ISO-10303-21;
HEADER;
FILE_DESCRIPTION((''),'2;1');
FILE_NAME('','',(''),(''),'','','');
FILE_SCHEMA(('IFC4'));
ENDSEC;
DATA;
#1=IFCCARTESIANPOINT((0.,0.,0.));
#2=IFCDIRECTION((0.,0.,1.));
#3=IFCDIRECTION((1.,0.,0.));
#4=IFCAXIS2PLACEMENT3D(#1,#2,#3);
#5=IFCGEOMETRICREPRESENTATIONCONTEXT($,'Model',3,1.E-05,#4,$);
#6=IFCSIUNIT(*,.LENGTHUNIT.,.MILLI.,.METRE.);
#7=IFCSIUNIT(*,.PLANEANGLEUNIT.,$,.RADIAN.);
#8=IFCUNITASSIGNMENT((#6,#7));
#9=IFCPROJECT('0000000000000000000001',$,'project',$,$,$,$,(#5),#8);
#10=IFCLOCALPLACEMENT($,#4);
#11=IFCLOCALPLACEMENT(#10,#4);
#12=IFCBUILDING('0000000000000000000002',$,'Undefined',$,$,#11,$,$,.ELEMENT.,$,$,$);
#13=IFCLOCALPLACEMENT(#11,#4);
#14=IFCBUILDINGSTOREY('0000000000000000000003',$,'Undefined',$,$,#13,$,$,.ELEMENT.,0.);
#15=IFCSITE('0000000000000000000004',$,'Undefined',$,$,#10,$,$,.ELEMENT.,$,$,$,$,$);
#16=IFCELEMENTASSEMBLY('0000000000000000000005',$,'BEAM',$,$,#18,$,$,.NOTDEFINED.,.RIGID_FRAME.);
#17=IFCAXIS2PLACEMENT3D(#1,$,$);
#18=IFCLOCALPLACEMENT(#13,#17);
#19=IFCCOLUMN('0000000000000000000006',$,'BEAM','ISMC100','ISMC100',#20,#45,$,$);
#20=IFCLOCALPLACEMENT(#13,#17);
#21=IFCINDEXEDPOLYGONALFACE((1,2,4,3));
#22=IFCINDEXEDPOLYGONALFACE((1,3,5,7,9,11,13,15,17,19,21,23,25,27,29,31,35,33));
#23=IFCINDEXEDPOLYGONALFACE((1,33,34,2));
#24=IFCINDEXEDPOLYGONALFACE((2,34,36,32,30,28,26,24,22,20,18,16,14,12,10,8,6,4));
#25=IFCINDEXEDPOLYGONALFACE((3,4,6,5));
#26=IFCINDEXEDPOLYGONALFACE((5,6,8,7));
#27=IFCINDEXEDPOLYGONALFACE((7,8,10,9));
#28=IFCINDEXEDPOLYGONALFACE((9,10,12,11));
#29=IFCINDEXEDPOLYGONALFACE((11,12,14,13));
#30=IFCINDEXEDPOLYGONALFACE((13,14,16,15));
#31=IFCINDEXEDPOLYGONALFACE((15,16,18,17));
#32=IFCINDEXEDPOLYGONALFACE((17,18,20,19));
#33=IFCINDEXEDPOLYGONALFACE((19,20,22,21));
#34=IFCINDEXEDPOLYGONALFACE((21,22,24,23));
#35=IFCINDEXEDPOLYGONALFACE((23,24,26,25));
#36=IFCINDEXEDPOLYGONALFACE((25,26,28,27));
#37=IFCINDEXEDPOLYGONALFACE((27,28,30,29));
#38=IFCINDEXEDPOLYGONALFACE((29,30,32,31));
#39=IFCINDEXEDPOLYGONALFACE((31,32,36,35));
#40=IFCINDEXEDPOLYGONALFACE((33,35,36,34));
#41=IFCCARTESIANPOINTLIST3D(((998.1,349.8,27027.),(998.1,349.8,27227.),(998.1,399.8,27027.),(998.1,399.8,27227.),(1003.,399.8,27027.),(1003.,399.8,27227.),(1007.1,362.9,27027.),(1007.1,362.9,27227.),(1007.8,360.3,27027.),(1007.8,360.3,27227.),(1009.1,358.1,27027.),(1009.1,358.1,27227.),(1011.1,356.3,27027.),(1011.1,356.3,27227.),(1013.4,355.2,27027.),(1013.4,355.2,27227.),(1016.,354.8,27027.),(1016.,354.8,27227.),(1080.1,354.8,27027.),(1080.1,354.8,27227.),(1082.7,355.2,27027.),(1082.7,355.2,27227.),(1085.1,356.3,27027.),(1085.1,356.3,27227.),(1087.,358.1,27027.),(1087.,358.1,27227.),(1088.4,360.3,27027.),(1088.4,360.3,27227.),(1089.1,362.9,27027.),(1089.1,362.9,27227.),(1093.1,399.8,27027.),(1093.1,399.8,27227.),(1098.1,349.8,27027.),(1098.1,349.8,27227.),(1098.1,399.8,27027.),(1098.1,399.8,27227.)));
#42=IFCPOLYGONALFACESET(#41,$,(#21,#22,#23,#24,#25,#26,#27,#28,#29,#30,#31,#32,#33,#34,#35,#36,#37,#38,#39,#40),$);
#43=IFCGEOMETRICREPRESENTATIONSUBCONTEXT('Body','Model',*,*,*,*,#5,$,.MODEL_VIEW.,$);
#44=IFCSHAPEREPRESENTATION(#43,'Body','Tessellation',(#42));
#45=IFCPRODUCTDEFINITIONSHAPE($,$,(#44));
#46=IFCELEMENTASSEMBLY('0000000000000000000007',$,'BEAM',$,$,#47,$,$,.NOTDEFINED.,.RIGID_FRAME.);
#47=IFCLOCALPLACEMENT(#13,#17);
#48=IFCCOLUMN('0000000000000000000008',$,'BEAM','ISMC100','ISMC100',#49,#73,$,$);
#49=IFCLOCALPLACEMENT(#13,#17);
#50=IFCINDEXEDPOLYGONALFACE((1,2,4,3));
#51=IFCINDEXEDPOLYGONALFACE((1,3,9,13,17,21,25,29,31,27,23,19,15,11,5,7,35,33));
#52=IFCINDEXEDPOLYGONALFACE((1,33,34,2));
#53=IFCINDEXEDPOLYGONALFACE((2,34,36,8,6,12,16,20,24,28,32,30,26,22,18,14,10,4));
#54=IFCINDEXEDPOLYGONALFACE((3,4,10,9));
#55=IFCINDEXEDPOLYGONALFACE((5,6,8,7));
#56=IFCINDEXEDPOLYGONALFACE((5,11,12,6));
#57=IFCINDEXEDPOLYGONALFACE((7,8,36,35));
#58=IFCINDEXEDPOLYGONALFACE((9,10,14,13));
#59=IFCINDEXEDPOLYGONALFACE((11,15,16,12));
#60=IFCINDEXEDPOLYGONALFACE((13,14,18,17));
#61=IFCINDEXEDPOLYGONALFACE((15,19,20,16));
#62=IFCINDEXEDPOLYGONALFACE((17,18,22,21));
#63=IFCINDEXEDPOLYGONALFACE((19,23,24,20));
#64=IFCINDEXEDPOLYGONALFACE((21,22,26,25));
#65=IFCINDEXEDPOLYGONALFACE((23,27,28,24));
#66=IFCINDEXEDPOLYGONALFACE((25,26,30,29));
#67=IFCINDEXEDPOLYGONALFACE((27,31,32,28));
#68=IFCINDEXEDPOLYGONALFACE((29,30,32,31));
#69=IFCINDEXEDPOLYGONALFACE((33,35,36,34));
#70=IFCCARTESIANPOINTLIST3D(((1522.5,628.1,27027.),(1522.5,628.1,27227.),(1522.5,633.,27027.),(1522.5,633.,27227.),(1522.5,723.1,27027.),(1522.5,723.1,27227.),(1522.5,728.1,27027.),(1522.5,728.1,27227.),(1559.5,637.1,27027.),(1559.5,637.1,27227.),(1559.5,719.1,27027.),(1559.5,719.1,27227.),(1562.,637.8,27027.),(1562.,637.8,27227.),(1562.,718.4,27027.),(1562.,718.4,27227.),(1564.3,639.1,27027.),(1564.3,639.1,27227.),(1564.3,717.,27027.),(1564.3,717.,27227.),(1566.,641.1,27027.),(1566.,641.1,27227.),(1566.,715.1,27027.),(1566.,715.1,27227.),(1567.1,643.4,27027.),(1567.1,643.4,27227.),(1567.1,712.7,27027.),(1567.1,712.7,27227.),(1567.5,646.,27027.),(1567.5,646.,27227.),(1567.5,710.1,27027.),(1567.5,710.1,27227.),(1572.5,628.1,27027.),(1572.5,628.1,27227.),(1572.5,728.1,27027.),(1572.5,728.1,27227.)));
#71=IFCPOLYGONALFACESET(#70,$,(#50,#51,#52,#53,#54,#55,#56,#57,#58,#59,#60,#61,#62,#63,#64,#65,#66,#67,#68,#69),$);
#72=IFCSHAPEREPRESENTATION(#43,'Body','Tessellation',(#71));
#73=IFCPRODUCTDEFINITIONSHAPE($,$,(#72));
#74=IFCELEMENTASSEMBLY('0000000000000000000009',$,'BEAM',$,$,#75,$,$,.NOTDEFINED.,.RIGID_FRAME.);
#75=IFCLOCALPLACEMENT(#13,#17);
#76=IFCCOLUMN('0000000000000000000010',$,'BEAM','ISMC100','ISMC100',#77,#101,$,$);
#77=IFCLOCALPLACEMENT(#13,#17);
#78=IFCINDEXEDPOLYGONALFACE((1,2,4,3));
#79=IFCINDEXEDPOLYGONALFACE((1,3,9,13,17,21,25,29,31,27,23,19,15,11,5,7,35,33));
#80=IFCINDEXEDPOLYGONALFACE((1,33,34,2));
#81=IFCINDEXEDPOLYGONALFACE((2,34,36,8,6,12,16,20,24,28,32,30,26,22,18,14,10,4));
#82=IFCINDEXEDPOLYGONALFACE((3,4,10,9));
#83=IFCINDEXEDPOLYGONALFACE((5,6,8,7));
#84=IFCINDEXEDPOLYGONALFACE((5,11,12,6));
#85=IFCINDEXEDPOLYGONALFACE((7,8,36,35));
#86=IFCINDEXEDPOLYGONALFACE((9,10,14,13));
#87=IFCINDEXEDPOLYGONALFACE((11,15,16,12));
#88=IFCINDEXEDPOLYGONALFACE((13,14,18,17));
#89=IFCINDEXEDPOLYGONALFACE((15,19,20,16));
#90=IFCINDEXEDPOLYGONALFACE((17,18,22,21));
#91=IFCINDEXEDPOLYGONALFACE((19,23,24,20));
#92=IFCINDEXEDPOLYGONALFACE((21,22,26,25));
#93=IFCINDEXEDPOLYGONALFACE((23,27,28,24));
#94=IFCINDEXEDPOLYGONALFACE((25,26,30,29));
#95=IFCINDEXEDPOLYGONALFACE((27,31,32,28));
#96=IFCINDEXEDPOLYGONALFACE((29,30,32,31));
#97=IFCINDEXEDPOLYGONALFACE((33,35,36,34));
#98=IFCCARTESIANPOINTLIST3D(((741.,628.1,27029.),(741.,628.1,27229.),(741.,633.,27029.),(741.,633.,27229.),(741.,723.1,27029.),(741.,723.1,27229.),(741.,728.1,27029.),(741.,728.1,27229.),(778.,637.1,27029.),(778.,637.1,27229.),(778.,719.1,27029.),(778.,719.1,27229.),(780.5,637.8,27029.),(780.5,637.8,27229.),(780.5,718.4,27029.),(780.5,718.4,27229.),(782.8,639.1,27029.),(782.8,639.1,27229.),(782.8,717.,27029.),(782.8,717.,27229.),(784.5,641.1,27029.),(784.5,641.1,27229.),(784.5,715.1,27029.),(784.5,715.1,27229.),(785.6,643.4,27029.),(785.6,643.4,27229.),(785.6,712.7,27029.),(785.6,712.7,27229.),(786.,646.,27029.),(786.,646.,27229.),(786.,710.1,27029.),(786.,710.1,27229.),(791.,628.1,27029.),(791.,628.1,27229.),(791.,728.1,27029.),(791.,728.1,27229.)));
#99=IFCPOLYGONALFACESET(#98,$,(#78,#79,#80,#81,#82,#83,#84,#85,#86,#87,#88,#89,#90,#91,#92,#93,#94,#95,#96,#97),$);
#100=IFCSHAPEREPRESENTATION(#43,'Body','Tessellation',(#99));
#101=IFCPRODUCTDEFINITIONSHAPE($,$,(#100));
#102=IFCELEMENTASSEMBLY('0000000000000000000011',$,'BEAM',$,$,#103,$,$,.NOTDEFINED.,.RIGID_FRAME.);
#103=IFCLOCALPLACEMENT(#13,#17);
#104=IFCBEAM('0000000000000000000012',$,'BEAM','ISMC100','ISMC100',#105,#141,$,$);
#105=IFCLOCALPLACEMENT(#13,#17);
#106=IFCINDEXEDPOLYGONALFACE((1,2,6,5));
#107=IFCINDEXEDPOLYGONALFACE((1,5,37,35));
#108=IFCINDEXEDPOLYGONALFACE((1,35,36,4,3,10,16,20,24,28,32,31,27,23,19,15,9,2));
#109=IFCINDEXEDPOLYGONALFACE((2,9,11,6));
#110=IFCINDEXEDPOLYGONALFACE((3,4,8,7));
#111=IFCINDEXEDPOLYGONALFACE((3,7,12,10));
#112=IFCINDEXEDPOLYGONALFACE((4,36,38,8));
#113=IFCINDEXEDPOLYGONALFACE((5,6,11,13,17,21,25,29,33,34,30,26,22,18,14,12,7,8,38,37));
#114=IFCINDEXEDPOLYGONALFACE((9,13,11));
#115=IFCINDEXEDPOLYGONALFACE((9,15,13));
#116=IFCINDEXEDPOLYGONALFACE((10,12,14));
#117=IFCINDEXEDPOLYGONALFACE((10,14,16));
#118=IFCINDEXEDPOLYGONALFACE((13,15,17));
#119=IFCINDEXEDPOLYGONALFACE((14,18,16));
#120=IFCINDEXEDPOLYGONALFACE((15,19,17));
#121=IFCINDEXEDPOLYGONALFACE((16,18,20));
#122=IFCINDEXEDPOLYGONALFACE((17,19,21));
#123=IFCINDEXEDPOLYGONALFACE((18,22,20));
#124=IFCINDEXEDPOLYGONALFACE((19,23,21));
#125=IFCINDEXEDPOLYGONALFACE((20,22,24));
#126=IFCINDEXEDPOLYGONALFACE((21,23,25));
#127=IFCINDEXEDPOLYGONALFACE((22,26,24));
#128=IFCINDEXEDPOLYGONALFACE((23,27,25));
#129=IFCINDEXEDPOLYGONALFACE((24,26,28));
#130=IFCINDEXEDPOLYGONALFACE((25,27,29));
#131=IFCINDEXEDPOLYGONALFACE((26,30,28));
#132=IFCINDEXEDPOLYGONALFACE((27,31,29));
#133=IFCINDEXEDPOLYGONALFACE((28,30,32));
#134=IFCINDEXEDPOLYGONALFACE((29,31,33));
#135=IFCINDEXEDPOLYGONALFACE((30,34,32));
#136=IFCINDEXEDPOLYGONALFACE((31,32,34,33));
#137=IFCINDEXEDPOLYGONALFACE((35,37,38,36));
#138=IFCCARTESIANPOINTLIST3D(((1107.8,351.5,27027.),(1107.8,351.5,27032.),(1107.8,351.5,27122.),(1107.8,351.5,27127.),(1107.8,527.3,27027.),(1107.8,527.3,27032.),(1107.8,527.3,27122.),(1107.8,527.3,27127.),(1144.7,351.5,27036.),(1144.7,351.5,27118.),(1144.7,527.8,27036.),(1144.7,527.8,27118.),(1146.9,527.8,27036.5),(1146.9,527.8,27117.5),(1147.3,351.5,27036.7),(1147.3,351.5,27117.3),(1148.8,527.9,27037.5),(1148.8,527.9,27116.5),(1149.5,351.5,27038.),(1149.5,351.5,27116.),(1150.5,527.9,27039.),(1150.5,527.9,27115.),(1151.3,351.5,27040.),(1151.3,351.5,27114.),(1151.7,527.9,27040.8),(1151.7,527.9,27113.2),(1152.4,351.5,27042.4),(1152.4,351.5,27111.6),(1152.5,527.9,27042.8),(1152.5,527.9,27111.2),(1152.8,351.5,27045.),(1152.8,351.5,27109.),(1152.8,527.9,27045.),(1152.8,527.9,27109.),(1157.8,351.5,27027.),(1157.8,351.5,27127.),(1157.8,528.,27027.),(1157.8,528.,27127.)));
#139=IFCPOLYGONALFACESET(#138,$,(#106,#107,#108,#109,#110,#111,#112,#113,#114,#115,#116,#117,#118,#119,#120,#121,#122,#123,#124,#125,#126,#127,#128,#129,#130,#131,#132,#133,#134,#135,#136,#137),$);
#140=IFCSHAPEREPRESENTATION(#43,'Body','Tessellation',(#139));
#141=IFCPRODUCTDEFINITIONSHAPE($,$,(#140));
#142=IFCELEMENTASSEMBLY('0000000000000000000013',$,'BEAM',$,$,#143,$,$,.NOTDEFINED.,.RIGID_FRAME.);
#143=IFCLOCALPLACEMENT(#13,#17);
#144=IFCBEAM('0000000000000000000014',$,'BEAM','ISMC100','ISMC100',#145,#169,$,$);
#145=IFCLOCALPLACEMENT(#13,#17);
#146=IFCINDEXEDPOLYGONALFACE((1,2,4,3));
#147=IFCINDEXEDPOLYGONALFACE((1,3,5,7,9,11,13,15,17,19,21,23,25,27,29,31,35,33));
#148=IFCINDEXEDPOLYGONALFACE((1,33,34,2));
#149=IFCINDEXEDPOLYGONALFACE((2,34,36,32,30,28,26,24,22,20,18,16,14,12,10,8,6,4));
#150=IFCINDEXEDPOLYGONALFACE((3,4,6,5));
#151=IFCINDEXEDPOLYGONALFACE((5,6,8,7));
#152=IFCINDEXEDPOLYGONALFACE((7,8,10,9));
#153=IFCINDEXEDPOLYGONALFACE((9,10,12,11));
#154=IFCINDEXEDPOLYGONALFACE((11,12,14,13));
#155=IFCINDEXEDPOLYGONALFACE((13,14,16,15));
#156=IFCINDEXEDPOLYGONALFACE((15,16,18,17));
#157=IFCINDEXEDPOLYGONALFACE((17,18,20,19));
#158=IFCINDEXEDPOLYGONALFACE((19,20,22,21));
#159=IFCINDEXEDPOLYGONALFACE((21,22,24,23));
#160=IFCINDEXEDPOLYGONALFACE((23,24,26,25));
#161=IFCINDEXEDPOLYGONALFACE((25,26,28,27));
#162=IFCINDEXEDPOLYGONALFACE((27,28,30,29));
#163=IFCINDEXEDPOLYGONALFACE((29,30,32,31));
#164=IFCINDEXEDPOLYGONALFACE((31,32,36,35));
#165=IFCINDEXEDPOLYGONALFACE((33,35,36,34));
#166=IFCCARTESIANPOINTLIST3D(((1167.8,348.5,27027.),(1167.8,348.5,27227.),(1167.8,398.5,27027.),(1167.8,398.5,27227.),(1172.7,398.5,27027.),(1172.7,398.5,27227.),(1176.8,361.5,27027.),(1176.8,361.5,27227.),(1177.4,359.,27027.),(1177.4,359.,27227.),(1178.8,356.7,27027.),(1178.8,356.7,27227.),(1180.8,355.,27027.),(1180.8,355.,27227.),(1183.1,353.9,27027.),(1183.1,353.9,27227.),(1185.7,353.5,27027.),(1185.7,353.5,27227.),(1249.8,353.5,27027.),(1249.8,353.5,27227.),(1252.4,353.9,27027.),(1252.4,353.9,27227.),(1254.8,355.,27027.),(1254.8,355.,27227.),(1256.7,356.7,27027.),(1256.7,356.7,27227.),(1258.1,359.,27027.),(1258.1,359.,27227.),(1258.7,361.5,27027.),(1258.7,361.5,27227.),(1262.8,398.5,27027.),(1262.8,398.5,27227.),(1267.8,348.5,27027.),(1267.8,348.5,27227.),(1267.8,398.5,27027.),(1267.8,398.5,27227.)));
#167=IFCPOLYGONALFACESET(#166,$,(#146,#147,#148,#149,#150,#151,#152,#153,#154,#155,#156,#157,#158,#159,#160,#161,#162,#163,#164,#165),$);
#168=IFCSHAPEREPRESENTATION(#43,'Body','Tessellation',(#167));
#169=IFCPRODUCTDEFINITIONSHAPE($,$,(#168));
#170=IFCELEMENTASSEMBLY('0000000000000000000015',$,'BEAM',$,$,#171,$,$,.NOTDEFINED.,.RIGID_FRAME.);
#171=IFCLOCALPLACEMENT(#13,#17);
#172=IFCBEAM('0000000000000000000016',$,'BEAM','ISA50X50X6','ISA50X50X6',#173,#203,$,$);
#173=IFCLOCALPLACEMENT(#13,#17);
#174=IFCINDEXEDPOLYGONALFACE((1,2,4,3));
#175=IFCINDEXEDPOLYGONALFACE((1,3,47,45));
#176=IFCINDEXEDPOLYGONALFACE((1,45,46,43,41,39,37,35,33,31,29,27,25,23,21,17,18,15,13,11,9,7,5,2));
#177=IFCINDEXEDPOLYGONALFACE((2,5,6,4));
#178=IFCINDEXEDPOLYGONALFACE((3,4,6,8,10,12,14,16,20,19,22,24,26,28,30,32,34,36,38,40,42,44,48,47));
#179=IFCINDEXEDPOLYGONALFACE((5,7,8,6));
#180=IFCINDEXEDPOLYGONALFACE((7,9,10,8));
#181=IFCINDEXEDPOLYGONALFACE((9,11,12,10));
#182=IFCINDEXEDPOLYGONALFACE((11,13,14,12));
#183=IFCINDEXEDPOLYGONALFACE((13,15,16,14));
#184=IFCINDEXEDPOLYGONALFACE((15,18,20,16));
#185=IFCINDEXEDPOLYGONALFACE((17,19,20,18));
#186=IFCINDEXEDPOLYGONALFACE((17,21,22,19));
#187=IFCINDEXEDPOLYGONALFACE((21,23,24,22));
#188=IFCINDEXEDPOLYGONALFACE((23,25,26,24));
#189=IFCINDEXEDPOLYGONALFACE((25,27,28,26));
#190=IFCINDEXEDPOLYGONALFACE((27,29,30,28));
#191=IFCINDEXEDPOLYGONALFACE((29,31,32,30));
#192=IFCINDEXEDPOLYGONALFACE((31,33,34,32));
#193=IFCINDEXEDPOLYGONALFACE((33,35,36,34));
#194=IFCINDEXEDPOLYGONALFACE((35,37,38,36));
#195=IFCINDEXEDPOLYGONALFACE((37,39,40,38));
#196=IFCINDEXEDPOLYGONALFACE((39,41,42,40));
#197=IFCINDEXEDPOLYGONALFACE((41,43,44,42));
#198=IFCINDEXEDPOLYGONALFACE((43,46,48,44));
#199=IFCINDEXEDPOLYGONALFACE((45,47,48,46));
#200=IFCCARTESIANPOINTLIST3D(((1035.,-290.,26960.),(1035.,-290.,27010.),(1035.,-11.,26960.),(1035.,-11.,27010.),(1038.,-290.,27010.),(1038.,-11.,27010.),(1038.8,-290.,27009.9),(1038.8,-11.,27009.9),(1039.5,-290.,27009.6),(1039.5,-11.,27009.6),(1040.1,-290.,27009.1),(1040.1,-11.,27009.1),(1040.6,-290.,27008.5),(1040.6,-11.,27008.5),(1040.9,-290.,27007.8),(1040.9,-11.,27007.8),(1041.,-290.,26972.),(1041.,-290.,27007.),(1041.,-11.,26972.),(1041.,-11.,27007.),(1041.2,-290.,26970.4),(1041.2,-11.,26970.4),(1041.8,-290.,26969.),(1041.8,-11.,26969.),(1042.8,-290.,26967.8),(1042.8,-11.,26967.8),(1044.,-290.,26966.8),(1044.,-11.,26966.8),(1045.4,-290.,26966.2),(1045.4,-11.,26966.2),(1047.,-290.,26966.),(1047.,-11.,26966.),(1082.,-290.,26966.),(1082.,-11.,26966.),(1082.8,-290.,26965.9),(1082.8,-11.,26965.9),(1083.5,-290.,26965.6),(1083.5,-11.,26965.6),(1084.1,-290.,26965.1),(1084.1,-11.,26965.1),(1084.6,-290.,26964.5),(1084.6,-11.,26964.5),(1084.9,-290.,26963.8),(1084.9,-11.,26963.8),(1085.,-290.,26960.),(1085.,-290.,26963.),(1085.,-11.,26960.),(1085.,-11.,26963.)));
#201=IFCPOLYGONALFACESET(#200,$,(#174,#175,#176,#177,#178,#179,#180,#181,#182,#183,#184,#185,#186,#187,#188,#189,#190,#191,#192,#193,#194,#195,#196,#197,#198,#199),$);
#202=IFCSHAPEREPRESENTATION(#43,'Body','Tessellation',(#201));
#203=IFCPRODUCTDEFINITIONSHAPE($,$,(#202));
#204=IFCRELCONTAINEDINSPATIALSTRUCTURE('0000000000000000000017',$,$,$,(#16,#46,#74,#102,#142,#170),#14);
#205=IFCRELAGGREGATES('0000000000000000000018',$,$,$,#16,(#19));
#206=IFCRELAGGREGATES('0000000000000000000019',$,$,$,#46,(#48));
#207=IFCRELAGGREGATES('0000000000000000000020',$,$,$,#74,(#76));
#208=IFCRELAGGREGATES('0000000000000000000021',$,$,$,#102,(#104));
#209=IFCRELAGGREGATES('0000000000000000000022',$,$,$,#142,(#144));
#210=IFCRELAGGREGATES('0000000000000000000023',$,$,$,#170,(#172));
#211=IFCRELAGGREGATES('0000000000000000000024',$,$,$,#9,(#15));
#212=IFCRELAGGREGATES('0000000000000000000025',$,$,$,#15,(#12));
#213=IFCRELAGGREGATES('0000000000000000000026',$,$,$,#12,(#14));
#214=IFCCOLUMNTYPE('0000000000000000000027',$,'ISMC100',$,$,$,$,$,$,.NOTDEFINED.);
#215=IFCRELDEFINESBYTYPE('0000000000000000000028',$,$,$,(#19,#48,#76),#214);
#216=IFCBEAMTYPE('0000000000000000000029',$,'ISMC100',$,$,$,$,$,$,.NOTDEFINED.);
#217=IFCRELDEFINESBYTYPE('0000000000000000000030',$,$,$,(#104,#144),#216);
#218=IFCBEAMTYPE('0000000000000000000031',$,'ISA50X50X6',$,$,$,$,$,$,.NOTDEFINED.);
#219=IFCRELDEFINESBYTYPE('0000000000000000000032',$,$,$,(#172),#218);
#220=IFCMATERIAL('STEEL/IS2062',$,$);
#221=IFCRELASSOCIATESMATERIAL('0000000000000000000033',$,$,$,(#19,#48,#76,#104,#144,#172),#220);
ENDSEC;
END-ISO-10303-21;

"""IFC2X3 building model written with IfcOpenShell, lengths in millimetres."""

from ifc_helpers import new_model, si_unit, frame, origin_with_axes, origin_2d_with_axis, place, context, subcontext, project, spatial, l_section, u_section, extrude, clip, halfspace, material, type_object, element, aggregate, save


model = new_model("IFC2X3")

# Units and contexts
model_context = context("Model", 3, precision=1e-05, world=origin_with_axes())
body_context = subcontext(model_context, "Body", "Model", "MODEL_VIEW")
ifc_project = project(units=[si_unit("LENGTHUNIT", "METRE", prefix="MILLI"), si_unit("PLANEANGLEUNIT", "RADIAN")], contexts=[model_context])

# Site, building, storey
site_placement = place(None, origin_with_axes())
site = spatial("IfcSite", under=ifc_project, at=site_placement, Name="Undefined", CompositionType="ELEMENT")
building_placement = place(site_placement, origin_with_axes())
building = spatial("IfcBuilding", under=site, at=building_placement, Name="Undefined", CompositionType="ELEMENT")
storey_placement = place(building_placement, origin_with_axes())
storey = spatial("IfcBuildingStorey", under=building, at=storey_placement, Name="Undefined", CompositionType="ELEMENT", Elevation=0.0)

# Element assemblies, columns
assembly_1_placement = place(storey_placement, origin_with_axes())
assembly_1 = element("IfcElementAssembly", 1, at=assembly_1_placement, inside=storey, Name="BEAM", AssemblyPlace="NOTDEFINED", PredefinedType="RIGID_FRAME")
ifc_material_1 = material(Name="STEEL/IS2062")
column_type = type_object("IfcColumnType", Name="ISMC100", PredefinedType="NOTDEFINED")
column_1_placement = place(assembly_1_placement, frame((1048.1, 374.8, 27027.0), z_axis=(0.0, 0.0, 1.0), x_axis=(1.0, 0.0, 0.0)))
column_1 = element("IfcColumn", 2, at=column_1_placement, type_object=column_type, material=ifc_material_1, Name="BEAM", Description="ISMC100", ObjectType="ISMC100", context=body_context, shape_type="SweptSolid", body=[
    extrude(u_section(Depth=100.0, FlangeWidth=50.0, WebThickness=5.0, FlangeThickness=7.7, FilletRadius=9.0, FlangeSlope=0.10956, at=origin_2d_with_axis()), frame((0.0, 0.0, 200.0), z_axis=(0.0, 0.0, -1.0), x_axis=(0.0, 1.0, 0.0)), (0.0, 0.0, 1.0), 200.0),
])
aggregate(assembly_1, [column_1])
assembly_2_placement = place(storey_placement, origin_with_axes())
assembly_2 = element("IfcElementAssembly", 3, at=assembly_2_placement, inside=storey, Name="BEAM", AssemblyPlace="NOTDEFINED", PredefinedType="RIGID_FRAME")
column_2_placement = place(assembly_2_placement, frame((1547.5, 678.1, 27027.0), z_axis=(0.0, 0.0, 1.0), x_axis=(0.0, 1.0, 0.0)))
column_2 = element("IfcColumn", 4, at=column_2_placement, type_object=column_type, material=ifc_material_1, Name="BEAM", Description="ISMC100", ObjectType="ISMC100", context=body_context, shape_type="SweptSolid", body=[
    extrude(u_section(Depth=100.0, FlangeWidth=50.0, WebThickness=5.0, FlangeThickness=7.7, FilletRadius=9.0, FlangeSlope=0.10956, at=origin_2d_with_axis()), frame((0.0, 0.0, 200.0), z_axis=(0.0, 0.0, -1.0), x_axis=(0.0, 1.0, 0.0)), (0.0, 0.0, 1.0), 200.0),
])
aggregate(assembly_2, [column_2])
assembly_3_placement = place(storey_placement, origin_with_axes())
assembly_3 = element("IfcElementAssembly", 5, at=assembly_3_placement, inside=storey, Name="BEAM", AssemblyPlace="NOTDEFINED", PredefinedType="RIGID_FRAME")
column_3_placement = place(assembly_3_placement, frame((766.0, 678.1, 27029.0), z_axis=(0.0, 0.0, 1.0), x_axis=(0.0, 1.0, 0.0)))
column_3 = element("IfcColumn", 6, at=column_3_placement, type_object=column_type, material=ifc_material_1, Name="BEAM", Description="ISMC100", ObjectType="ISMC100", context=body_context, shape_type="SweptSolid", body=[
    extrude(u_section(Depth=100.0, FlangeWidth=50.0, WebThickness=5.0, FlangeThickness=7.7, FilletRadius=9.0, FlangeSlope=0.10956, at=origin_2d_with_axis()), frame((0.0, 0.0, 200.0), z_axis=(0.0, 0.0, -1.0), x_axis=(0.0, 1.0, 0.0)), (0.0, 0.0, 1.0), 200.0),
])
aggregate(assembly_3, [column_3])

# Element assemblies, beams
assembly_4_placement = place(storey_placement, origin_with_axes())
assembly_4 = element("IfcElementAssembly", 7, at=assembly_4_placement, inside=storey, Name="BEAM", AssemblyPlace="NOTDEFINED", PredefinedType="RIGID_FRAME")
beam_type_1 = type_object("IfcBeamType", Name="ISMC100", PredefinedType="NOTDEFINED")
beam_1_placement = place(assembly_4_placement, frame((1132.8, 351.5, 27077.0), z_axis=(0.0, 0.0, -1.0), x_axis=(0.0, 1.0, 0.0)))
beam_1 = element("IfcBeam", 8, at=beam_1_placement, type_object=beam_type_1, material=ifc_material_1, Name="BEAM", Description="ISMC100", ObjectType="ISMC100", context=body_context, shape_type="Clipping", body=[
    clip(extrude(u_section(Depth=100.0, FlangeWidth=50.0, WebThickness=5.0, FlangeThickness=7.7, FilletRadius=9.0, FlangeSlope=0.10956, at=origin_2d_with_axis()), frame((176.5, 0.0, 0.0), z_axis=(-1.0, 0.0, 0.0), x_axis=(0.0, -1.0, 0.0)), (0.0, 0.0, 1.0), 176.5), halfspace(frame((176.5, 25.0, -50.0), z_axis=(0.999902, -0.013997, 0.0), x_axis=(-0.013997, -0.999902, 0.0)), False)),
])
aggregate(assembly_4, [beam_1])
assembly_5_placement = place(storey_placement, origin_with_axes())
assembly_5 = element("IfcElementAssembly", 9, at=assembly_5_placement, inside=storey, Name="BEAM", AssemblyPlace="NOTDEFINED", PredefinedType="RIGID_FRAME")
beam_2_placement = place(assembly_5_placement, frame((1217.8, 373.5, 27227.0), z_axis=(-1.0, 0.0, 0.0), x_axis=(0.0, 0.0, -1.0)))
beam_2 = element("IfcBeam", 10, at=beam_2_placement, type_object=beam_type_1, material=ifc_material_1, Name="BEAM", Description="ISMC100", ObjectType="ISMC100", context=body_context, shape_type="SweptSolid", body=[
    extrude(u_section(Depth=100.0, FlangeWidth=50.0, WebThickness=5.0, FlangeThickness=7.7, FilletRadius=9.0, FlangeSlope=0.10956, at=origin_2d_with_axis()), frame((200.0, 0.0, 0.0), z_axis=(-1.0, 0.0, 0.0), x_axis=(0.0, -1.0, 0.0)), (0.0, 0.0, 1.0), 200.0),
])
aggregate(assembly_5, [beam_2])
assembly_6_placement = place(storey_placement, origin_with_axes())
assembly_6 = element("IfcElementAssembly", 11, at=assembly_6_placement, inside=storey, Name="BEAM", AssemblyPlace="NOTDEFINED", PredefinedType="RIGID_FRAME")
beam_type_2 = type_object("IfcBeamType", Name="ISA50X50X6", PredefinedType="NOTDEFINED")
beam_3_placement = place(assembly_6_placement, frame((1060.0, -290.0, 26985.0), z_axis=(0.0, 0.0, 1.0), x_axis=(0.0, 1.0, 0.0)))
beam_3 = element("IfcBeam", 12, at=beam_3_placement, type_object=beam_type_2, material=ifc_material_1, Name="BEAM", Description="ISA50X50X6", ObjectType="ISA50X50X6", context=body_context, shape_type="SweptSolid", body=[
    extrude(l_section(Depth=50.0, Width=50.0, Thickness=6.0, FilletRadius=6.0, EdgeRadius=3.0, at=origin_2d_with_axis()), frame((279.0, 0.0, 0.0), z_axis=(-1.0, 0.0, 0.0), x_axis=(0.0, -1.0, 0.0)), (0.0, 0.0, 1.0), 279.0),
])
aggregate(assembly_6, [beam_3])

save(model, "model.ifc")
